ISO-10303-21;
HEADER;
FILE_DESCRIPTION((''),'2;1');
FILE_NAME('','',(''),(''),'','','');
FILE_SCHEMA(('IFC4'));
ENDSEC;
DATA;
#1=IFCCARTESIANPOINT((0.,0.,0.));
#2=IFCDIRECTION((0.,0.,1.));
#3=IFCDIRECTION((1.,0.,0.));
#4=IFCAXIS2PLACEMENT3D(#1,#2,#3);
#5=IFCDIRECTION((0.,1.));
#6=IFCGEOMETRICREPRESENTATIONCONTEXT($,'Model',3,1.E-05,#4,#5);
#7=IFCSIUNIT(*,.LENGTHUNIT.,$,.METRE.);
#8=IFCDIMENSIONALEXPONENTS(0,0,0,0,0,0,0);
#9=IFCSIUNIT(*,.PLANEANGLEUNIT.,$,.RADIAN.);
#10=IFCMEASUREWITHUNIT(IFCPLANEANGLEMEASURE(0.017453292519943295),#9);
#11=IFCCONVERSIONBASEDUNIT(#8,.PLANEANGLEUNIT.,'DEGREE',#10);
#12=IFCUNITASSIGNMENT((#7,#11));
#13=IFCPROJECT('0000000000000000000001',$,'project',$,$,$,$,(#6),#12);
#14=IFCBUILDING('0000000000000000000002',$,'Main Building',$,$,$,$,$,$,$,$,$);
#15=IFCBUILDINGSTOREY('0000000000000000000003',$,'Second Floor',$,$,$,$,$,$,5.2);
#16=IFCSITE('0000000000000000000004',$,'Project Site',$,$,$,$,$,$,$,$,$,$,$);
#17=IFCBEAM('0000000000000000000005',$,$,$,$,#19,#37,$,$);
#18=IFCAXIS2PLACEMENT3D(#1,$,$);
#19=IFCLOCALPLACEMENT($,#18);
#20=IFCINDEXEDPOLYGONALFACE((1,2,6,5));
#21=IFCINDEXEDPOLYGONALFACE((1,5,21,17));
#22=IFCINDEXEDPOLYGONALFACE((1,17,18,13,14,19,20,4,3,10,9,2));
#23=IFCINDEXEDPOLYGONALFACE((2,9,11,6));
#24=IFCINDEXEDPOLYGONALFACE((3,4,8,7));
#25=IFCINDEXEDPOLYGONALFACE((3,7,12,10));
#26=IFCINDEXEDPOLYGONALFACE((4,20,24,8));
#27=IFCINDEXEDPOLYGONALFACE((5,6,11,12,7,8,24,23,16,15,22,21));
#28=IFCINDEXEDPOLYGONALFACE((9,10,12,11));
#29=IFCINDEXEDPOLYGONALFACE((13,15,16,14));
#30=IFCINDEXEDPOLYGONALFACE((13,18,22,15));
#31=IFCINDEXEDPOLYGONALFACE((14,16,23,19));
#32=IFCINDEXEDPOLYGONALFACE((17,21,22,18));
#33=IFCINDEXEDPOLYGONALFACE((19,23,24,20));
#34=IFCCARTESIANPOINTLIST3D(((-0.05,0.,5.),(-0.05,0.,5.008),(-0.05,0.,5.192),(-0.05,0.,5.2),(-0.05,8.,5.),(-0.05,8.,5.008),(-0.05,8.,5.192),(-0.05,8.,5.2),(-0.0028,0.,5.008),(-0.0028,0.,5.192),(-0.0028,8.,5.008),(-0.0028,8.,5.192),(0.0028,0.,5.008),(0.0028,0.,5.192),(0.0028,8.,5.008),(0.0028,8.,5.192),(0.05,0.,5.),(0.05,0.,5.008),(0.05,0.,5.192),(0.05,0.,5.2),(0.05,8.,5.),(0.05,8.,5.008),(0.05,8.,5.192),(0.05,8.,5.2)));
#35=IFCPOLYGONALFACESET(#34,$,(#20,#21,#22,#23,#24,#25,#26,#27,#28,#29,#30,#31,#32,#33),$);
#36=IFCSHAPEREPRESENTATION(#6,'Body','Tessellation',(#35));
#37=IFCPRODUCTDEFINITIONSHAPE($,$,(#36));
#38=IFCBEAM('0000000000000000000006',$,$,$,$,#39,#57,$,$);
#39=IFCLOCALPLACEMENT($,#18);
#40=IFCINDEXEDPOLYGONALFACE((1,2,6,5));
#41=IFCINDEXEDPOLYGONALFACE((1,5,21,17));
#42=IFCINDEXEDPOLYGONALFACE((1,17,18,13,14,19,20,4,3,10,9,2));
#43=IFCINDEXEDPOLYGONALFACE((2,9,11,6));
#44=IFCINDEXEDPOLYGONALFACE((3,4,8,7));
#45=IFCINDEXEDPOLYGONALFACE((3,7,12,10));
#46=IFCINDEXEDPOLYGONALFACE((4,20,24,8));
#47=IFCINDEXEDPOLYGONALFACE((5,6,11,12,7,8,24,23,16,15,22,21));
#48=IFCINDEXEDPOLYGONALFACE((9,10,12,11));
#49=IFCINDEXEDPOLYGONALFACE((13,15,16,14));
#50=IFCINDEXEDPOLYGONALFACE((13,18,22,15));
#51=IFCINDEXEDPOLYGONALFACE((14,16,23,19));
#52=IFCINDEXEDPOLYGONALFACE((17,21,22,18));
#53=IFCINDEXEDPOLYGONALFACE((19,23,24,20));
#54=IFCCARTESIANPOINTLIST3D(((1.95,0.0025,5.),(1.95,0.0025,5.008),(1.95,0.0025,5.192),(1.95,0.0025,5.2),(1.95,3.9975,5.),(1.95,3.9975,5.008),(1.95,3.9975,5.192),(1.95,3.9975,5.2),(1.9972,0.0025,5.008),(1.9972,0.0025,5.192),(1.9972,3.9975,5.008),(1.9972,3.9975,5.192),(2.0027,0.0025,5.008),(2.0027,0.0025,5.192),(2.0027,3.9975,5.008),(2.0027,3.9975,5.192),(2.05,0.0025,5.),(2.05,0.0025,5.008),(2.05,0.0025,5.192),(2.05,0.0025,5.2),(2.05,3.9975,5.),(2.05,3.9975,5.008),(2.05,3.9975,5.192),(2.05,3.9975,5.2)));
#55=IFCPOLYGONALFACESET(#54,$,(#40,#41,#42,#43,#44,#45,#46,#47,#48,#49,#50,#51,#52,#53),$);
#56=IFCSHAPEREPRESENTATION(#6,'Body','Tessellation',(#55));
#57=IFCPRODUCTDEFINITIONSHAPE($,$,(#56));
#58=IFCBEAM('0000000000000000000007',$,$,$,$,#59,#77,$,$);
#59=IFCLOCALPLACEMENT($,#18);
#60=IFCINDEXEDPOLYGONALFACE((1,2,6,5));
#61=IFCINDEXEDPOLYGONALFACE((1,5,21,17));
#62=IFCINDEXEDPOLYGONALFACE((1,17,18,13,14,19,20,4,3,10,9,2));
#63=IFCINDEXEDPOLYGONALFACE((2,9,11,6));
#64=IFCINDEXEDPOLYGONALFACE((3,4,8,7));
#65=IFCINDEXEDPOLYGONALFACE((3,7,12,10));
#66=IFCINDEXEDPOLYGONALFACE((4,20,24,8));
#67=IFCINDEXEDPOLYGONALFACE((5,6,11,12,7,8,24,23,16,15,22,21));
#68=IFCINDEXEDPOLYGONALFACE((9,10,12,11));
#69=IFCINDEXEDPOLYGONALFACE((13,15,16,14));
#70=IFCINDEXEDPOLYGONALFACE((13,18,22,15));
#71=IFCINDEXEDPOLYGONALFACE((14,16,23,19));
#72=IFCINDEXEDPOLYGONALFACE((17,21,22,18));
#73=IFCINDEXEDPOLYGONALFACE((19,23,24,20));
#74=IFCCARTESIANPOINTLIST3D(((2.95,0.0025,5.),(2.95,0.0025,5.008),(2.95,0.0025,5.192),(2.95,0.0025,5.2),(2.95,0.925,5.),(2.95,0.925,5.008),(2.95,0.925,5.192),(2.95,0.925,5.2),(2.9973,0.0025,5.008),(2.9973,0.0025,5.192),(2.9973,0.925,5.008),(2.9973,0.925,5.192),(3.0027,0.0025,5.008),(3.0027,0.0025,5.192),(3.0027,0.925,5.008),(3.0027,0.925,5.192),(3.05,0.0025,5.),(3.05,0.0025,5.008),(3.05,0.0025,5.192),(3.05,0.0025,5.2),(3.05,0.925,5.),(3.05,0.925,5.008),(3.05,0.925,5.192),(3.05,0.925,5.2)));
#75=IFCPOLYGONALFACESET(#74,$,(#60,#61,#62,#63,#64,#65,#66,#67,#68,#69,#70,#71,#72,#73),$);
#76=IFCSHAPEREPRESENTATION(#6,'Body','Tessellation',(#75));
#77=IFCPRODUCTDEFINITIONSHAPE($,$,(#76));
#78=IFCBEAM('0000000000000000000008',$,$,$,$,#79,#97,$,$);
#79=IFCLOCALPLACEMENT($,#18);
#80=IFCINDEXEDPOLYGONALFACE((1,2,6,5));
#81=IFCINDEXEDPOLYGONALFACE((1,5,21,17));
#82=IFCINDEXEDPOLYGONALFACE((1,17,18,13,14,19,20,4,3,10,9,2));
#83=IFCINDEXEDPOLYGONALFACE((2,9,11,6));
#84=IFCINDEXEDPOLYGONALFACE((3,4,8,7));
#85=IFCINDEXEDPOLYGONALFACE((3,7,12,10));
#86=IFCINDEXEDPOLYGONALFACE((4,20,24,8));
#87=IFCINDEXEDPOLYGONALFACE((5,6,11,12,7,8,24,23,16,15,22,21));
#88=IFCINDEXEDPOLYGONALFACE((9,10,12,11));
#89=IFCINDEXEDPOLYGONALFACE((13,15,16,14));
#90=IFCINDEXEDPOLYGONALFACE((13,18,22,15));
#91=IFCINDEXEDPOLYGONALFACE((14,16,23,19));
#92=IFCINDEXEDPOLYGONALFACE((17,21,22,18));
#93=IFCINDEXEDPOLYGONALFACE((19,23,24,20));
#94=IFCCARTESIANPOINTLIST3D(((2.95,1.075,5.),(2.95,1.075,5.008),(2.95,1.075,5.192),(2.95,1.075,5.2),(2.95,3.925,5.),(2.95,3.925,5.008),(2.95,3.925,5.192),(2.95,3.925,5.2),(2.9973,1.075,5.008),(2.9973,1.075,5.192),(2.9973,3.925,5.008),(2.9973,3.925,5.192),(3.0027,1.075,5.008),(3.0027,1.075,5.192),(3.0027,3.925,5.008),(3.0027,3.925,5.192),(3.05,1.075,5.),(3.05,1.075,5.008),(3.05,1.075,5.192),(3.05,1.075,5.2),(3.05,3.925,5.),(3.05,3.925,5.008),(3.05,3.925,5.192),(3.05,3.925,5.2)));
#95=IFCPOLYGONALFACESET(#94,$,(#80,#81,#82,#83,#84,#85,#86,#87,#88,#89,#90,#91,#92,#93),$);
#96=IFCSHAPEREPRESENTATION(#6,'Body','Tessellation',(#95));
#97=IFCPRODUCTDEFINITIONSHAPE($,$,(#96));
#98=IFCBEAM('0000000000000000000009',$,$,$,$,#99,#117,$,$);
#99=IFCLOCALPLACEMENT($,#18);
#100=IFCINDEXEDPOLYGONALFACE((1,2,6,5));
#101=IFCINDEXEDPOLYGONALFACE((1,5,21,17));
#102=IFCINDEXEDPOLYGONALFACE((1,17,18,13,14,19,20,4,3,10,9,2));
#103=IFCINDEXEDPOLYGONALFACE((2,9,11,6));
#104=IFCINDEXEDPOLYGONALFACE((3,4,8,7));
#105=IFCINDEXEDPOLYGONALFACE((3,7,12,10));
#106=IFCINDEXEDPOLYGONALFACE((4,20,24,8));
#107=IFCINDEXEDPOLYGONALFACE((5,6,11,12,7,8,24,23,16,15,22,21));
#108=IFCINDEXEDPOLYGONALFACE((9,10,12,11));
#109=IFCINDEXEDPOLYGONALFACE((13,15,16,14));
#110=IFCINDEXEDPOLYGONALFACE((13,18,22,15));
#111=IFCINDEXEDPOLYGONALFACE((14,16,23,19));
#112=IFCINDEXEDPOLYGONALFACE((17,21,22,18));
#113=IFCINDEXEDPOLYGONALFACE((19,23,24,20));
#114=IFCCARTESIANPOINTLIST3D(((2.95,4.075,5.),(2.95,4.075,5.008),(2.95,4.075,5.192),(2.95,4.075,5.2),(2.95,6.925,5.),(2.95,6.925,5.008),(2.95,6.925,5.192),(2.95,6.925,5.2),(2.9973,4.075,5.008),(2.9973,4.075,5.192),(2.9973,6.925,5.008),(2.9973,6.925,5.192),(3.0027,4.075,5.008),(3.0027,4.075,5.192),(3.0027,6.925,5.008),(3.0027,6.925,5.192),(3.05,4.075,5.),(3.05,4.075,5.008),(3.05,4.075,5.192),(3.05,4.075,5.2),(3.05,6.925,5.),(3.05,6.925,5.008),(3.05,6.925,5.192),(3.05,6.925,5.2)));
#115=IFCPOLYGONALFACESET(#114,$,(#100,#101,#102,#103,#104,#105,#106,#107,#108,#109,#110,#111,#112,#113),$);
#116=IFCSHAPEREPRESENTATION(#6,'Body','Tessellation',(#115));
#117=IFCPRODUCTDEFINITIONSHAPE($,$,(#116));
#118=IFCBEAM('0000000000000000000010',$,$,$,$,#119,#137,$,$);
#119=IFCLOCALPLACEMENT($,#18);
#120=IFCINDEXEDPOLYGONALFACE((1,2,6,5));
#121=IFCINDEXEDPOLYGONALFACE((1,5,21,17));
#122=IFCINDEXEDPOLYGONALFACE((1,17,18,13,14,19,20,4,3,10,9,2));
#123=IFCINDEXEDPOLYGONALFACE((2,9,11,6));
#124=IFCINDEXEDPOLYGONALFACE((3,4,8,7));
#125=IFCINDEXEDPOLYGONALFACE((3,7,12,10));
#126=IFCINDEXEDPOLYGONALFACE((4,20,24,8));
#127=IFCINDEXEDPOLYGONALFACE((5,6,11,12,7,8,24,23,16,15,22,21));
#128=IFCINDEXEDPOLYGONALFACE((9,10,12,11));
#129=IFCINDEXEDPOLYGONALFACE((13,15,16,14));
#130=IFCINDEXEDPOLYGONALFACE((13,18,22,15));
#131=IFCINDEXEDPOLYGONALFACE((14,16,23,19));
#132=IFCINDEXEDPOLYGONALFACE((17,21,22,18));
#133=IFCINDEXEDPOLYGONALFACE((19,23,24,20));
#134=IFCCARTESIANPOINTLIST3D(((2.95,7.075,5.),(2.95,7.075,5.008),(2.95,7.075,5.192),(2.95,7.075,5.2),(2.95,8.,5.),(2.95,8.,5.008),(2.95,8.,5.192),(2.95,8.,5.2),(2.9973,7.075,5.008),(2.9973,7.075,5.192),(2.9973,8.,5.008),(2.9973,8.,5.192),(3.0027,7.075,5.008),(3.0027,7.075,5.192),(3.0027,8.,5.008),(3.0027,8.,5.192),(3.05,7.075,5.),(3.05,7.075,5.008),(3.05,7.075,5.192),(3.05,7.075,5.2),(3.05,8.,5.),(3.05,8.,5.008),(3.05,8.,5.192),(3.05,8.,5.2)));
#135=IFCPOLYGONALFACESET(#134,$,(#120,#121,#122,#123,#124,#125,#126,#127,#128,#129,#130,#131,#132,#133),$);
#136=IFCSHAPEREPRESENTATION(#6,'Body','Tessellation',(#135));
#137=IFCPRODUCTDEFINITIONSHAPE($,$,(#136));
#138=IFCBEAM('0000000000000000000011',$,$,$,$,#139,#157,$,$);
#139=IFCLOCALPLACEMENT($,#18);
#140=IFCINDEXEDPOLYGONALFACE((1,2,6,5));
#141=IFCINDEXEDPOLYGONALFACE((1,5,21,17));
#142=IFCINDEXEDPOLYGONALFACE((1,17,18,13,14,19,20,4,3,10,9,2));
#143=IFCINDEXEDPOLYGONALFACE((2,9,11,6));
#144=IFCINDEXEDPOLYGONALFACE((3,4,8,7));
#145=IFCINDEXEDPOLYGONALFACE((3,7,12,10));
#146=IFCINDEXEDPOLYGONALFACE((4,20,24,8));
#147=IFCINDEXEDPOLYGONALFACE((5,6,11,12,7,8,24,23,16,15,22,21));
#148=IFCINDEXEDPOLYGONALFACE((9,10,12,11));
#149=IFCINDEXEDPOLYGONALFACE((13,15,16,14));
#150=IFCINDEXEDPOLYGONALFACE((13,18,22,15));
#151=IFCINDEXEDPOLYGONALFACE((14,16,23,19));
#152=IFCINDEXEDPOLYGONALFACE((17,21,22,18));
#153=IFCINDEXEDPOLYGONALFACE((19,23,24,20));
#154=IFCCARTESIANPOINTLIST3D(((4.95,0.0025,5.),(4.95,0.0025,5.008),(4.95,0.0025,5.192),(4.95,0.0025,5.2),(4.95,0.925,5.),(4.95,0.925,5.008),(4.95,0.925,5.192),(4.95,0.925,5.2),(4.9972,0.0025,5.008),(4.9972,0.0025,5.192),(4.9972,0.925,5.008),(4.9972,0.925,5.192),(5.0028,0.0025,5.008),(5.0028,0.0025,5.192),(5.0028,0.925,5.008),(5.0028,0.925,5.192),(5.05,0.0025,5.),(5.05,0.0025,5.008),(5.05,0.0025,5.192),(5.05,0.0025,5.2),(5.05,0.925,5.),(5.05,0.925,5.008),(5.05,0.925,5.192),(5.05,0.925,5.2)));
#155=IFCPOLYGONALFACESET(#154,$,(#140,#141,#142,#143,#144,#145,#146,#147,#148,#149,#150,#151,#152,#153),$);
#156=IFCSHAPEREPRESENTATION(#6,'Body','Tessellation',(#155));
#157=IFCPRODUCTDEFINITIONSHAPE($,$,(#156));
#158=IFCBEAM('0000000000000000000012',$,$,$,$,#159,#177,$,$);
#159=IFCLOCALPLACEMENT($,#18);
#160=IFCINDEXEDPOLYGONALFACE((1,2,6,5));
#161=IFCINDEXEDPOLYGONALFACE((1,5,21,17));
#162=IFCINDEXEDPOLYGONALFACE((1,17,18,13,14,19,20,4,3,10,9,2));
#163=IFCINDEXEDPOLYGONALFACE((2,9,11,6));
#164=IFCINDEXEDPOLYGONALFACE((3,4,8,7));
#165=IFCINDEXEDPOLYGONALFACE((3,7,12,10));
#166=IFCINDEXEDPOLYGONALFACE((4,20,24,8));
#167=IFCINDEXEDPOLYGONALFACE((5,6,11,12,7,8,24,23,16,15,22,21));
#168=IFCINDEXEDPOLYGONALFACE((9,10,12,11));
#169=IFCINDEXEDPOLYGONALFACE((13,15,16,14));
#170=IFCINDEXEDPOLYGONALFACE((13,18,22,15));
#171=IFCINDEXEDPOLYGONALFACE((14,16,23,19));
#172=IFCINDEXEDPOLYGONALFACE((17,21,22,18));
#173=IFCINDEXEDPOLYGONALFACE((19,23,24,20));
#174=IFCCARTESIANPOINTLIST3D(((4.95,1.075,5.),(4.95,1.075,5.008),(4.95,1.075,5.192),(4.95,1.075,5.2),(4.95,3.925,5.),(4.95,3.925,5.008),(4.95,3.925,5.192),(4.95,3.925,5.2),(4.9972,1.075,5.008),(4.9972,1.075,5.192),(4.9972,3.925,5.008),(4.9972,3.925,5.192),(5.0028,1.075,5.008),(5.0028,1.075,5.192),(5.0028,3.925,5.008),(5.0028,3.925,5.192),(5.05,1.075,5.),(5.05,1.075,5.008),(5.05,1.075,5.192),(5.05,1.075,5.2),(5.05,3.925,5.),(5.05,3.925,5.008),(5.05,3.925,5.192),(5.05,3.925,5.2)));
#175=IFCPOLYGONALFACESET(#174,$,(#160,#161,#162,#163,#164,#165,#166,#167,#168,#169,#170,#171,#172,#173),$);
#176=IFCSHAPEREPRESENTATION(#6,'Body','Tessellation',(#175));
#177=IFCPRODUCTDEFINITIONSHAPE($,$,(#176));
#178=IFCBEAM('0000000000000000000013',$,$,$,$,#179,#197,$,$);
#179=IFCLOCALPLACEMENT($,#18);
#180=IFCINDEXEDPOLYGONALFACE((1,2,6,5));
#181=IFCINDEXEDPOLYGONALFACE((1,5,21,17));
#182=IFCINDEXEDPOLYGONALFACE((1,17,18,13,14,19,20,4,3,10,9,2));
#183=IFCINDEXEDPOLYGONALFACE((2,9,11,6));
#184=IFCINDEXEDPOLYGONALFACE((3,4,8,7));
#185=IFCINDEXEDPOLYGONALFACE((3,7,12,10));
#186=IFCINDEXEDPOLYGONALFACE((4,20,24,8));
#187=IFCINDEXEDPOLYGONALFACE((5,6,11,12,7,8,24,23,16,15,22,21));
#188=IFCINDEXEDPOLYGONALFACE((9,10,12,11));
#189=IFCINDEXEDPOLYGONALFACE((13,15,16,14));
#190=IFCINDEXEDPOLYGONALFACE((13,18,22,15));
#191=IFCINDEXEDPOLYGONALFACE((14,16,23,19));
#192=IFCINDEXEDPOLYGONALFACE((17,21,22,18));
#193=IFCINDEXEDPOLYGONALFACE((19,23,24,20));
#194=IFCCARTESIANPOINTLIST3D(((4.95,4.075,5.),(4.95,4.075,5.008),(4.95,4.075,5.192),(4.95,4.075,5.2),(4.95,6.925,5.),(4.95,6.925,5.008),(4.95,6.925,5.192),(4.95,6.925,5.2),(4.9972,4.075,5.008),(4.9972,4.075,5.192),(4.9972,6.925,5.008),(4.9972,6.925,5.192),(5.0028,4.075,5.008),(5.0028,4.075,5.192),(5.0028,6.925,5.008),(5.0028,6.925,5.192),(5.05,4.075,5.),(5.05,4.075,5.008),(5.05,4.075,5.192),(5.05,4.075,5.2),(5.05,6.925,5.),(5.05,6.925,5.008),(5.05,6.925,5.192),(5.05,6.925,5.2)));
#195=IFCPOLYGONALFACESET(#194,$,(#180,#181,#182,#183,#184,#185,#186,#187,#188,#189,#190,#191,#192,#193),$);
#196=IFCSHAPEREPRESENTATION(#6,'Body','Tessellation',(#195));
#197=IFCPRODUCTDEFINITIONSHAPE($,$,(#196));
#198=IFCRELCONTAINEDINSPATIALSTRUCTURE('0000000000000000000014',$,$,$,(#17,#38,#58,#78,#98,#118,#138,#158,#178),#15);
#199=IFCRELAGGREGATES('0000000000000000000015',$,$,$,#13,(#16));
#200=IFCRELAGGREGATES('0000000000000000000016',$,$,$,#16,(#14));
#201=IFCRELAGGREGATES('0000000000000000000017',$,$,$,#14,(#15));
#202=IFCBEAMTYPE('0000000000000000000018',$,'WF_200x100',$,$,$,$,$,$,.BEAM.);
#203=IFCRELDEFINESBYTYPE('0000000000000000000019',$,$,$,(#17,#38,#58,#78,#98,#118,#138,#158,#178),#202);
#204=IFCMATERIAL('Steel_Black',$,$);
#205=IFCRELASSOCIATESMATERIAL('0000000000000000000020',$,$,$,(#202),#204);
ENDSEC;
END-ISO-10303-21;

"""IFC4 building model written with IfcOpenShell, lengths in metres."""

from ifc_helpers import new_model, entity, si_unit, converted_unit, direction, frame, frame_2d, origin_with_axes, origin_2d, place, context, project, spatial, i_section, extrude, material, material_profile, profile_set, type_object, element, save


model = new_model("IFC4")

# Units and contexts
model_context = context("Model", 3, precision=1e-05, world=origin_with_axes(), true_north=direction((0.0, 1.0)))
ifc_project = project(units=[si_unit("LENGTHUNIT", "METRE"), converted_unit("PLANEANGLEUNIT", "DEGREE", entity("IfcPlaneAngleMeasure", 0.017453292519943295), si_unit("PLANEANGLEUNIT", "RADIAN"), dimensions=[0, 0, 0, 0, 0, 0, 0])], contexts=[model_context])

# Site, building, storey
site = spatial("IfcSite", under=ifc_project, Name="Project Site")
building = spatial("IfcBuilding", under=site, Name="Main Building")
storey = spatial("IfcBuildingStorey", under=building, Name="Second Floor", Elevation=5.2)

# Beams
ifc_material = material(Name="Steel_Black")
ifc_material_profile_1 = material_profile(ifc_material, i_section(OverallWidth=0.1, OverallDepth=0.2, WebThickness=0.0055, FlangeThickness=0.008, at=origin_2d()), Name="WF_200x100")
ifc_profile_set_1 = profile_set([ifc_material_profile_1], Name="WF_200x100")
beam_type_1 = type_object("IfcBeamType", Name="WF_200x100", PredefinedType="BEAM", material=ifc_profile_set_1)
beam_1_placement = place(None, frame((0.0, 0.0, 5.0), z_axis=(0.0, 0.0, 1.0), x_axis=(0.0, 1.0, 0.0)))
element("IfcBeam", 1, at=beam_1_placement, inside=storey, type_object=beam_type_1, context=model_context, shape_type="SweptSolid", body=[
    extrude(i_section(OverallWidth=0.1, OverallDepth=0.2, WebThickness=0.0055, FlangeThickness=0.008, at=frame_2d((0.0, 0.1))), frame((0.0, 0.0, 0.0), z_axis=(1.0, 0.0, 0.0), x_axis=(0.0, 1.0, 0.0)), (0.0, 0.0, 1.0), 8.0),
])
beam_2_placement = place(None, frame((2.0, 0.0025, 5.0), z_axis=(0.0, 0.0, 1.0), x_axis=(0.0, 1.0, 0.0)))
element("IfcBeam", 2, at=beam_2_placement, inside=storey, type_object=beam_type_1, context=model_context, shape_type="SweptSolid", body=[
    extrude(i_section(OverallWidth=0.1, OverallDepth=0.2, WebThickness=0.0055, FlangeThickness=0.008, at=frame_2d((0.0, 0.1))), frame((0.0, 0.0, 0.0), z_axis=(1.0, 0.0, 0.0), x_axis=(0.0, 1.0, 0.0)), (0.0, 0.0, 1.0), 3.995),
])
beam_3_placement = place(None, frame((3.0, 0.0025, 5.0), z_axis=(0.0, 0.0, 1.0), x_axis=(0.0, 1.0, 0.0)))
element("IfcBeam", 3, at=beam_3_placement, inside=storey, type_object=beam_type_1, context=model_context, shape_type="SweptSolid", body=[
    extrude(i_section(OverallWidth=0.1, OverallDepth=0.2, WebThickness=0.0055, FlangeThickness=0.008, at=frame_2d((0.0, 0.1))), frame((0.0, 0.0, 0.0), z_axis=(1.0, 0.0, 0.0), x_axis=(0.0, 1.0, 0.0)), (0.0, 0.0, 1.0), 0.9225),
])
for number, where, z_axis, x_axis in (
    (4, (3.0, 1.075, 5.0), (0.0, 0.0, 1.0), (0.0, 1.0, 0.0)),
    (5, (3.0, 4.075, 5.0), (0.0, 0.0, 1.0), (0.0, 1.0, 0.0)),
):
    element("IfcBeam", number, at=place(None, frame(where, z_axis=z_axis, x_axis=x_axis)), inside=storey, type_object=beam_type_1, context=model_context, shape_type="SweptSolid", body=[
        extrude(i_section(OverallWidth=0.1, OverallDepth=0.2, WebThickness=0.0055, FlangeThickness=0.008, at=frame_2d((0.0, 0.1))), frame((0.0, 0.0, 0.0), z_axis=(1.0, 0.0, 0.0), x_axis=(0.0, 1.0, 0.0)), (0.0, 0.0, 1.0), 2.85),
    ])
beam_4_placement = place(None, frame((3.0, 7.075, 5.0), z_axis=(0.0, 0.0, 1.0), x_axis=(0.0, 1.0, 0.0)))
element("IfcBeam", 6, at=beam_4_placement, inside=storey, type_object=beam_type_1, context=model_context, shape_type="SweptSolid", body=[
    extrude(i_section(OverallWidth=0.1, OverallDepth=0.2, WebThickness=0.0055, FlangeThickness=0.008, at=frame_2d((0.0, 0.1))), frame((0.0, 0.0, 0.0), z_axis=(1.0, 0.0, 0.0), x_axis=(0.0, 1.0, 0.0)), (0.0, 0.0, 1.0), 0.925),
])
beam_5_placement = place(None, frame((5.0, 0.0025, 5.0), z_axis=(0.0, 0.0, 1.0), x_axis=(0.0, 1.0, 0.0)))
element("IfcBeam", 7, at=beam_5_placement, inside=storey, type_object=beam_type_1, context=model_context, shape_type="SweptSolid", body=[
    extrude(i_section(OverallWidth=0.1, OverallDepth=0.2, WebThickness=0.0055, FlangeThickness=0.008, at=frame_2d((0.0, 0.1))), frame((0.0, 0.0, 0.0), z_axis=(1.0, 0.0, 0.0), x_axis=(0.0, 1.0, 0.0)), (0.0, 0.0, 1.0), 0.9225),
])
for number, where, z_axis, x_axis in (
    (8, (5.0, 1.075, 5.0), (0.0, 0.0, 1.0), (0.0, 1.0, 0.0)),
    (9, (5.0, 4.075, 5.0), (0.0, 0.0, 1.0), (0.0, 1.0, 0.0)),
):
    element("IfcBeam", number, at=place(None, frame(where, z_axis=z_axis, x_axis=x_axis)), inside=storey, type_object=beam_type_1, context=model_context, shape_type="SweptSolid", body=[
        extrude(i_section(OverallWidth=0.1, OverallDepth=0.2, WebThickness=0.0055, FlangeThickness=0.008, at=frame_2d((0.0, 0.1))), frame((0.0, 0.0, 0.0), z_axis=(1.0, 0.0, 0.0), x_axis=(0.0, 1.0, 0.0)), (0.0, 0.0, 1.0), 2.85),
    ])

save(model, "model.ifc")
